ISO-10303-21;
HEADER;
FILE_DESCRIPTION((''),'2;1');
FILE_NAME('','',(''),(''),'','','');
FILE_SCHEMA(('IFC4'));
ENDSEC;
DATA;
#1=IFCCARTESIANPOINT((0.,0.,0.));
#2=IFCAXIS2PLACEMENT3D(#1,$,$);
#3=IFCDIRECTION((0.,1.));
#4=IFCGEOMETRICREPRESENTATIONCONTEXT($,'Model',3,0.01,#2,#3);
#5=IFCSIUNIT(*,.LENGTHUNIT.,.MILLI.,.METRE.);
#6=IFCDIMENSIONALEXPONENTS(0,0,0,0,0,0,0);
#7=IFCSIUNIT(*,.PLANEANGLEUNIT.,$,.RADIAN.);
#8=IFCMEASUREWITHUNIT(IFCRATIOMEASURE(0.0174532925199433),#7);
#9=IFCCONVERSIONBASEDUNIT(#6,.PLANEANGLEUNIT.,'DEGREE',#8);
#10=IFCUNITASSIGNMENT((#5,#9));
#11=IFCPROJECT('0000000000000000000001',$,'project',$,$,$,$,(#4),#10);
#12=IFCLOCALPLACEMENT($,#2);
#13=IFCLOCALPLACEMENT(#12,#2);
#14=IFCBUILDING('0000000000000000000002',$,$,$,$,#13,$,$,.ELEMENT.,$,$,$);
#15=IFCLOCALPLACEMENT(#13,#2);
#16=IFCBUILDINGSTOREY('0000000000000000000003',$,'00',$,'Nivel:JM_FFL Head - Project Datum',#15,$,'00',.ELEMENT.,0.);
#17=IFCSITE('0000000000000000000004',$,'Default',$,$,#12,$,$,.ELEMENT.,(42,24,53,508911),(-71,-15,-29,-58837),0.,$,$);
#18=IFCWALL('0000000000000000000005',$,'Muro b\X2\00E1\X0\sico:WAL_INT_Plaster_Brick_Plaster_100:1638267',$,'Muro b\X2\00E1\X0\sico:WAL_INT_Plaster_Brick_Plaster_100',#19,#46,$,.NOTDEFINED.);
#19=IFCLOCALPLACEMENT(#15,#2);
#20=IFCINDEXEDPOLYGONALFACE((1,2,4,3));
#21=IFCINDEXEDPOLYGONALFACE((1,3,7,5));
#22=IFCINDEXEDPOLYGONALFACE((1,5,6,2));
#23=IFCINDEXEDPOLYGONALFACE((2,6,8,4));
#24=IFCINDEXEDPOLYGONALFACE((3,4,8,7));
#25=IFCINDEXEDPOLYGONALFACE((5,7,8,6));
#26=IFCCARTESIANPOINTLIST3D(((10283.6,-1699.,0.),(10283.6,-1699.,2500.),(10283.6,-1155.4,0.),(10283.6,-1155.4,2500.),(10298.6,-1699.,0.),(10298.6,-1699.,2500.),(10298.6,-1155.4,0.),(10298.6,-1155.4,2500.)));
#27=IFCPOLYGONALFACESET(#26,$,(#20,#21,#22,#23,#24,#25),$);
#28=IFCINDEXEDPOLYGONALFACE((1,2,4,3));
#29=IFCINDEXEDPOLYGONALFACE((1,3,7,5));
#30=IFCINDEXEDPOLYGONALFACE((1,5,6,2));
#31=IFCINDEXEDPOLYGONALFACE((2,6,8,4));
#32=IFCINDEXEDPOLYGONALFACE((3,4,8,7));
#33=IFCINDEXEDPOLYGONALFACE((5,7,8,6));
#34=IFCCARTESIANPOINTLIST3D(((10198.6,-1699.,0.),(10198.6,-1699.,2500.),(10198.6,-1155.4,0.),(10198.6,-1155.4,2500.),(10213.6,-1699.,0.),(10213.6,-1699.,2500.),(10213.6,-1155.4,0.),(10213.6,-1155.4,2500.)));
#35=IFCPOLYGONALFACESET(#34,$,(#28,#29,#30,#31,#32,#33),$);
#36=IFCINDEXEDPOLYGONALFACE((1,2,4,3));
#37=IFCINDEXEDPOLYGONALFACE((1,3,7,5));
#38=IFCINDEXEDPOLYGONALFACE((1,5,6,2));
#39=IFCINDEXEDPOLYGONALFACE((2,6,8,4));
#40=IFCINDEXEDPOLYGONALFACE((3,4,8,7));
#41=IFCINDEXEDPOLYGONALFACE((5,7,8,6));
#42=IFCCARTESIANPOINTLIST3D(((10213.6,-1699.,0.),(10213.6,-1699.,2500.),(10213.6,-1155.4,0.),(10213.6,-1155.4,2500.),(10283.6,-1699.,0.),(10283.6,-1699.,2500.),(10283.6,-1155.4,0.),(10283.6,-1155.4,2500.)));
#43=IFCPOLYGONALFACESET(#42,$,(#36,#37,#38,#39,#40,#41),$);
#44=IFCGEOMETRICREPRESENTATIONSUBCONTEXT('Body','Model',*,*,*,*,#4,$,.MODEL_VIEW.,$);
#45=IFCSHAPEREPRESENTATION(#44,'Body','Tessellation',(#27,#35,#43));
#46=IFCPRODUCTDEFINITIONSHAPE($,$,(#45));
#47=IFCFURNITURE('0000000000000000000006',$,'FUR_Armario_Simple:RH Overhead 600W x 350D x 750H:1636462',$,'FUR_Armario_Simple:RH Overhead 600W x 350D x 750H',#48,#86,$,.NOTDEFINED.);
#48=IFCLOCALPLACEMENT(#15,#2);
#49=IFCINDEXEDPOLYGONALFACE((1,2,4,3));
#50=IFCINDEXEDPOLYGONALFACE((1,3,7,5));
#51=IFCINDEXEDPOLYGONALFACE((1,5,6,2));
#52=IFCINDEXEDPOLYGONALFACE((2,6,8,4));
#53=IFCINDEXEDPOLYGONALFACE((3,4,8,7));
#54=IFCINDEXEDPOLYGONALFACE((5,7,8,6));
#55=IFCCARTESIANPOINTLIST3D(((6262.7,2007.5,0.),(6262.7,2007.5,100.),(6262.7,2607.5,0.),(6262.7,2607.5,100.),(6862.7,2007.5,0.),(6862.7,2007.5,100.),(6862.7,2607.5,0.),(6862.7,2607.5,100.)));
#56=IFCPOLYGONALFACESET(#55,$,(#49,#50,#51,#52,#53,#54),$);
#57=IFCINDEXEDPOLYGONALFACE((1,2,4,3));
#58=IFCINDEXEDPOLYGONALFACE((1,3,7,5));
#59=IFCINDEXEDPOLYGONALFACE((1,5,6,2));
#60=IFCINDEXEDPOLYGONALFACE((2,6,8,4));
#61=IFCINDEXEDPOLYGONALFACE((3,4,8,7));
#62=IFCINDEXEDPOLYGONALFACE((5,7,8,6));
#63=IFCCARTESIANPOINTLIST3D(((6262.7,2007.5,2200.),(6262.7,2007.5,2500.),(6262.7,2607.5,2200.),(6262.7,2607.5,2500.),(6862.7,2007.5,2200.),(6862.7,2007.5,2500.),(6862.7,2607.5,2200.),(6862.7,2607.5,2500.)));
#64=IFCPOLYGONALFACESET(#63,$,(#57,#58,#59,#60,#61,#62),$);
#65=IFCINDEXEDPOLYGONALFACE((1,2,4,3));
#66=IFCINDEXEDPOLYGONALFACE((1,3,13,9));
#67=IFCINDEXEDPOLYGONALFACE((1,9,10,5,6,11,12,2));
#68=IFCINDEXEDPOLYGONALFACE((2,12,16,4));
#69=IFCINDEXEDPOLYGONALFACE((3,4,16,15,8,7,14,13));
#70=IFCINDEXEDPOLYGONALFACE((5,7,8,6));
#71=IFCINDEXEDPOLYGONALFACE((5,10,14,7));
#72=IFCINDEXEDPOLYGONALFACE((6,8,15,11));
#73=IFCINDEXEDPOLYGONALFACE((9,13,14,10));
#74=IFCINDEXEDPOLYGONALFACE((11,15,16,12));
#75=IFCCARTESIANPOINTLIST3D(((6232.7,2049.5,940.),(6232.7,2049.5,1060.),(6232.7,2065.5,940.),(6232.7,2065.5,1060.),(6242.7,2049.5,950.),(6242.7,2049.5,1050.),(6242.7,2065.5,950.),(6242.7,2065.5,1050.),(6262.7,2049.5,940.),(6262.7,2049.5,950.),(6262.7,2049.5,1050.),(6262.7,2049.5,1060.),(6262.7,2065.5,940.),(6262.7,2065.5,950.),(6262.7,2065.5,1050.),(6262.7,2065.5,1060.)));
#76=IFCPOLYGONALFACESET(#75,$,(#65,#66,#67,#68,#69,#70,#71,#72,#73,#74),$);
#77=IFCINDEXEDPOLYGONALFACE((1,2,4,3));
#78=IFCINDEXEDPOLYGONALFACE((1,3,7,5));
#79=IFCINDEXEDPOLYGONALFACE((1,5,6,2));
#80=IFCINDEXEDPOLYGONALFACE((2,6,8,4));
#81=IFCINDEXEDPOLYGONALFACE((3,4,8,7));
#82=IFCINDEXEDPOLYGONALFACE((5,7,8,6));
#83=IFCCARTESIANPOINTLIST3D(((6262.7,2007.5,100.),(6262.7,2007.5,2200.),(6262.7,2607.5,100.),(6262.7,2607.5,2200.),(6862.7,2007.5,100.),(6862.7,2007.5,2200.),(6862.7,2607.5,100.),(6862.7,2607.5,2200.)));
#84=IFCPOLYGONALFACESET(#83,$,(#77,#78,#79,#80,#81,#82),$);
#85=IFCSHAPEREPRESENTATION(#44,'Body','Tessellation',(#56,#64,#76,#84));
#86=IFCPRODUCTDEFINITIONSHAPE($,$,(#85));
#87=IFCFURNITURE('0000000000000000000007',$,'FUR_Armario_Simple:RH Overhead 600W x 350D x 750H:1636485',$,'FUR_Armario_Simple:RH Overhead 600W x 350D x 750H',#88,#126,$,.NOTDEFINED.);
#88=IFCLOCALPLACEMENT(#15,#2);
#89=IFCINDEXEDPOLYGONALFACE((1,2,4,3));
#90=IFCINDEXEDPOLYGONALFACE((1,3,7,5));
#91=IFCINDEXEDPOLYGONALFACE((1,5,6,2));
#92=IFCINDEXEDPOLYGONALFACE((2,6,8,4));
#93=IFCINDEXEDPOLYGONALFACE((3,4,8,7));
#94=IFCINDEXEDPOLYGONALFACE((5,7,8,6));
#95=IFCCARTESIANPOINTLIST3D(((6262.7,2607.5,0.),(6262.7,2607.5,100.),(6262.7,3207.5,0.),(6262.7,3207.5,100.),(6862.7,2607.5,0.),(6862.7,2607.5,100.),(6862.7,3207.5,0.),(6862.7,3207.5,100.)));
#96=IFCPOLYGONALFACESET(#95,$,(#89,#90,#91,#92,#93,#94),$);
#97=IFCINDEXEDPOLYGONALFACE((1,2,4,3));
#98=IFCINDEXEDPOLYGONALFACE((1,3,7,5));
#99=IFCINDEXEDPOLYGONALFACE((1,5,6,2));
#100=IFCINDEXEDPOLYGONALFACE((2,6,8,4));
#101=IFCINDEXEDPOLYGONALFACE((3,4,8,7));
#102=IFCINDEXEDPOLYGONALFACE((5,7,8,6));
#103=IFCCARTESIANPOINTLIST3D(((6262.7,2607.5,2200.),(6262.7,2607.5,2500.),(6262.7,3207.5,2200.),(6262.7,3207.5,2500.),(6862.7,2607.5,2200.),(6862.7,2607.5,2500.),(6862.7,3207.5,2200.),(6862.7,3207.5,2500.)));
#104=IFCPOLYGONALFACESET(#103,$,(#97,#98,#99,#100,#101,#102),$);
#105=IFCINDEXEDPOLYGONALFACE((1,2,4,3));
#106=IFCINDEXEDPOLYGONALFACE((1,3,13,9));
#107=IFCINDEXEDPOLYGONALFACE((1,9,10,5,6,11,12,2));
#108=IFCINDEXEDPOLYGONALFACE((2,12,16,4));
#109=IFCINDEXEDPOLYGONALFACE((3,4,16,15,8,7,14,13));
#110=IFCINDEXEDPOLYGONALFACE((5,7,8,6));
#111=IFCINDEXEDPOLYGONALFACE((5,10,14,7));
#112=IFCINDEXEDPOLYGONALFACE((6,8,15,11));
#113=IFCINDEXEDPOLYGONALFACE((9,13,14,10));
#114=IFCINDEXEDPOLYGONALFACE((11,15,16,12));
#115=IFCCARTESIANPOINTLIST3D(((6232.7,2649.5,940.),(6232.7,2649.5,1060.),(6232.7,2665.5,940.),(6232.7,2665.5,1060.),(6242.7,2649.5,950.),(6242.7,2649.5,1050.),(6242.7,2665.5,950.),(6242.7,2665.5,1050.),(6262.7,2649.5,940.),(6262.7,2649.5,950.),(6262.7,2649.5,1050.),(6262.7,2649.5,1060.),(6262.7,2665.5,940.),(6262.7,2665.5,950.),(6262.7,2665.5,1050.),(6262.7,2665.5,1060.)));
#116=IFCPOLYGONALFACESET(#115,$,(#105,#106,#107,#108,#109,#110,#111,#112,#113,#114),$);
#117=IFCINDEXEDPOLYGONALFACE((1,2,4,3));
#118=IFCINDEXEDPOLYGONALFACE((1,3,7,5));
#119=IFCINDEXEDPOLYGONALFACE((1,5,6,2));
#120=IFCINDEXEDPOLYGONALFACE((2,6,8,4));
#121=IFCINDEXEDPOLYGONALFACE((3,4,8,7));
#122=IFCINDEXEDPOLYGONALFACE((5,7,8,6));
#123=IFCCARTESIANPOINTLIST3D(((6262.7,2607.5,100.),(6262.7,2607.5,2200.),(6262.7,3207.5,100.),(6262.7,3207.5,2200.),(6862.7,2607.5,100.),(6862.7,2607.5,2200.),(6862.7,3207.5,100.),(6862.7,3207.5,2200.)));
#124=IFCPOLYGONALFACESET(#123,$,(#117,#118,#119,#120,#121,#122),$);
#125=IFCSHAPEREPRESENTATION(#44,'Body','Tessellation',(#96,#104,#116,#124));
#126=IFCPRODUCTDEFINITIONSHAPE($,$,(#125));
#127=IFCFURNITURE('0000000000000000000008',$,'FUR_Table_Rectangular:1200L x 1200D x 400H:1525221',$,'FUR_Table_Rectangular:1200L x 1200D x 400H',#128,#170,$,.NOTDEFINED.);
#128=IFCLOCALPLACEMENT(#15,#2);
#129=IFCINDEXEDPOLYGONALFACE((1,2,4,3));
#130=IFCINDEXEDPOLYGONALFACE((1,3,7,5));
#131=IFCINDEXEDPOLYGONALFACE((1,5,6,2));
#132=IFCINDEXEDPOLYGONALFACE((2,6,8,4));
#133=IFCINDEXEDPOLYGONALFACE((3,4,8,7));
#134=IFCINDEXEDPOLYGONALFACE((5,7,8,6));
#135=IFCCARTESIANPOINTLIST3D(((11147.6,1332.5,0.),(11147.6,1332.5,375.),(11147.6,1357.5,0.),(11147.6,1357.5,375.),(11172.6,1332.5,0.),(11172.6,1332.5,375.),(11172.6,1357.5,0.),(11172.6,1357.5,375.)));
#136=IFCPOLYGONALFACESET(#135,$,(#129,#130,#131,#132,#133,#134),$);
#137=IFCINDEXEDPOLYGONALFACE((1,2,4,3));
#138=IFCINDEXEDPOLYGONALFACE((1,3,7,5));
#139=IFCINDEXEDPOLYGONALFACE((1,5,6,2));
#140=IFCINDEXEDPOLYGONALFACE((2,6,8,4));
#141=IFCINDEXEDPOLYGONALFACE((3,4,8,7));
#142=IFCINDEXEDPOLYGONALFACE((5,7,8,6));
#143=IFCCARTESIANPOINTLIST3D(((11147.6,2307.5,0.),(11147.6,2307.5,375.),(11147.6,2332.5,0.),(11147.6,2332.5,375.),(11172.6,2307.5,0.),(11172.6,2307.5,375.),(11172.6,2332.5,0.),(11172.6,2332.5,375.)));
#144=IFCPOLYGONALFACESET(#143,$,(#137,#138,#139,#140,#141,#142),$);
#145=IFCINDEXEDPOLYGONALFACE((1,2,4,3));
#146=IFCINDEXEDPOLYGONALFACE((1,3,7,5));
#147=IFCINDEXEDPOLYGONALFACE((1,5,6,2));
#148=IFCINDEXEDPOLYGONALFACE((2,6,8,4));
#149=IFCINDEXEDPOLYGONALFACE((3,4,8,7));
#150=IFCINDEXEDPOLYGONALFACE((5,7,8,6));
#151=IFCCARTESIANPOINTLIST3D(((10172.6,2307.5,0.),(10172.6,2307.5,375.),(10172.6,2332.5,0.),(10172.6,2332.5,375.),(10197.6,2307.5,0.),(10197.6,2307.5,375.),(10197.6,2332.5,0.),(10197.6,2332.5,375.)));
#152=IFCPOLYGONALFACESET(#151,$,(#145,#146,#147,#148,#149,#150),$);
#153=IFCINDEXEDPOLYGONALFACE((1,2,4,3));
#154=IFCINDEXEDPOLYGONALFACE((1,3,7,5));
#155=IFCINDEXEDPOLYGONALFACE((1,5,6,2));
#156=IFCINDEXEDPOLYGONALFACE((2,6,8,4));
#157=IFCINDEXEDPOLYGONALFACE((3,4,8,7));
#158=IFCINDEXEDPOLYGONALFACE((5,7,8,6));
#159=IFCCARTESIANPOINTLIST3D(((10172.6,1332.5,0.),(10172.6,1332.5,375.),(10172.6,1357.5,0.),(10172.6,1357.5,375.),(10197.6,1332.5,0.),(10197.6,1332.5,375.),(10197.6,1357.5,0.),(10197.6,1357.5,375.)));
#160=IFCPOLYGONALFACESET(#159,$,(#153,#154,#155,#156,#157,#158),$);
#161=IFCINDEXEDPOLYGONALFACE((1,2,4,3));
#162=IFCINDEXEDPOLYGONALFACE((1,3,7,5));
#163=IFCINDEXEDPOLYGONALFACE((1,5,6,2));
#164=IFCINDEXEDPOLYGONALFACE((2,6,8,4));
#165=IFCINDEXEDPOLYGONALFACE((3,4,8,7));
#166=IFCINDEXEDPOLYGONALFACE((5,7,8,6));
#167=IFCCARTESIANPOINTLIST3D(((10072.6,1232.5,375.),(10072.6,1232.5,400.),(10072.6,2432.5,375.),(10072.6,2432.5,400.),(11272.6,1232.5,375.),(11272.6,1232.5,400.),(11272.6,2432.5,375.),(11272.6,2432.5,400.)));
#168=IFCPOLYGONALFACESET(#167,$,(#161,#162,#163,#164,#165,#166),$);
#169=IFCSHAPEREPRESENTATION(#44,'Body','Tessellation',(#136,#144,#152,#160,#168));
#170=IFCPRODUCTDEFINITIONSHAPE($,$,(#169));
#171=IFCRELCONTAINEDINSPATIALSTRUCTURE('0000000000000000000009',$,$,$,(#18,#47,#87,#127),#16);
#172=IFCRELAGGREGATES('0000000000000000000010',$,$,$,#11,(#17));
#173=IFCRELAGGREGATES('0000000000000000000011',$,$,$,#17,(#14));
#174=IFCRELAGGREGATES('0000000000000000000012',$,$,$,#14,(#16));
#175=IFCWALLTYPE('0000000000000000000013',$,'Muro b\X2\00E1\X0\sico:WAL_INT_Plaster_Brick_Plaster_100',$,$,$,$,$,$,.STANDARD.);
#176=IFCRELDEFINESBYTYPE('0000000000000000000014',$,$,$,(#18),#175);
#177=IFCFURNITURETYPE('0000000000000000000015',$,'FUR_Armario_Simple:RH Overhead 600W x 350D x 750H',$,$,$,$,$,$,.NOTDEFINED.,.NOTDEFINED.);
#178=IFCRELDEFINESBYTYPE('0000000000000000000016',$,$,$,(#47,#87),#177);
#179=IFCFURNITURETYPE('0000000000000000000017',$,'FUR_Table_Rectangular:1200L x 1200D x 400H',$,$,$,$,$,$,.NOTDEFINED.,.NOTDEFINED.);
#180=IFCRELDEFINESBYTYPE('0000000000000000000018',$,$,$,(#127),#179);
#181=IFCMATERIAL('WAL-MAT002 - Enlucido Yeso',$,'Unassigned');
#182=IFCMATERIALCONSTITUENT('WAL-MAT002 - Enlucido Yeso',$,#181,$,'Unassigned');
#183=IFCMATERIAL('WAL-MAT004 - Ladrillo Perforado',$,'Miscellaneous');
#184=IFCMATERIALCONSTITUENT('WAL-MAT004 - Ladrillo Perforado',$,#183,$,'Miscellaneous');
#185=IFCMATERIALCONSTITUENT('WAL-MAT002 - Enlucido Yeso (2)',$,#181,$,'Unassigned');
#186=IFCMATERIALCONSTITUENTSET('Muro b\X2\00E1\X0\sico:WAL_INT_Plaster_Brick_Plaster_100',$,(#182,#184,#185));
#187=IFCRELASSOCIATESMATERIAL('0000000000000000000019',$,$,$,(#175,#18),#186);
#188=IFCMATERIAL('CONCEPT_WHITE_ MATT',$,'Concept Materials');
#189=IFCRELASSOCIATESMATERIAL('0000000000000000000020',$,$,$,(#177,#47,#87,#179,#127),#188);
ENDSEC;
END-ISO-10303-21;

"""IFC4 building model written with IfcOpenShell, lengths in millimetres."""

from ifc_helpers import new_model, entity, si_unit, converted_unit, direction, frame, origin, place, context, subcontext, project, spatial, indexed_curve, outline, extrude, source, transform, mapped, material, constituent, constituent_set, type_object, type_shapes, element, save


model = new_model("IFC4")

# Units and contexts
model_context = context("Model", 3, precision=0.01, world=origin(), true_north=direction((0.0, 1.0)))
body_context = subcontext(model_context, "Body", "Model", "MODEL_VIEW")
ifc_project = project(units=[si_unit("LENGTHUNIT", "METRE", prefix="MILLI"), converted_unit("PLANEANGLEUNIT", "DEGREE", entity("IfcRatioMeasure", 0.0174532925199433), si_unit("PLANEANGLEUNIT", "RADIAN"), dimensions=[0, 0, 0, 0, 0, 0, 0])], contexts=[model_context])

# Site, building, storey
site_placement = place(None, origin())
site = spatial("IfcSite", under=ifc_project, at=site_placement, Name="Default", CompositionType="ELEMENT", RefLatitude=(42, 24, 53, 508911), RefLongitude=(-71, -15, -29, -58837), RefElevation=0.0)
building_placement = place(site_placement, origin())
building = spatial("IfcBuilding", under=site, at=building_placement, CompositionType="ELEMENT")
storey_placement = place(building_placement, origin())
storey = spatial("IfcBuildingStorey", under=building, at=storey_placement, Name="00", ObjectType="Nivel:JM_FFL Head - Project Datum", LongName="00", CompositionType="ELEMENT", Elevation=0.0)

# Wall
ifc_material_1 = material(Name="WAL-MAT002 - Enlucido Yeso", Category="Unassigned")
ifc_constituent_1 = constituent(ifc_material_1, Name="WAL-MAT002 - Enlucido Yeso", Category="Unassigned")
ifc_material_2 = material(Name="WAL-MAT004 - Ladrillo Perforado", Category="Miscellaneous")
ifc_constituent_2 = constituent(ifc_material_2, Name="WAL-MAT004 - Ladrillo Perforado", Category="Miscellaneous")
ifc_constituent_3 = constituent(ifc_material_1, Name="WAL-MAT002 - Enlucido Yeso (2)", Category="Unassigned")
ifc_constituent_set_1 = constituent_set(constituents=[ifc_constituent_1, ifc_constituent_2, ifc_constituent_3], Name="Muro básico:WAL_INT_Plaster_Brick_Plaster_100")
wall_type = type_object("IfcWallType", Name="Muro básico:WAL_INT_Plaster_Brick_Plaster_100", PredefinedType="STANDARD", material=ifc_constituent_set_1)
wall_1_placement = place(storey_placement, frame((10248.6, -1155.4, 0.0), z_axis=(0.0, 0.0, 1.0), x_axis=(0.0, -1.0, 0.0)))
element("IfcWall", 1, at=wall_1_placement, inside=storey, type_object=wall_type, material=ifc_constituent_set_1, Name="Muro básico:WAL_INT_Plaster_Brick_Plaster_100:1638267", ObjectType="Muro básico:WAL_INT_Plaster_Brick_Plaster_100", PredefinedType="NOTDEFINED", context=body_context, shape_type="SweptSolid", body=[
    extrude(outline(indexed_curve([(-7.5, -271.8), (7.5, -271.8), (7.5, 271.8), (-7.5, 271.8), (-7.5, -271.8)], self_intersect=False)), frame((271.8, 42.5, 0.0), z_axis=(0.0, 0.0, 1.0), x_axis=(0.0, -1.0, 0.0)), (0.0, 0.0, 1.0), 2500.0),
    extrude(outline(indexed_curve([(-7.5, -271.8), (7.5, -271.8), (7.5, 271.8), (-7.5, 271.8), (-7.5, -271.8)], self_intersect=False)), frame((271.8, -42.5, 0.0), z_axis=(0.0, 0.0, 1.0), x_axis=(0.0, 1.0, 0.0)), (0.0, 0.0, 1.0), 2500.0),
    extrude(outline(indexed_curve([(-271.8, -35.0), (271.8, -35.0), (271.8, 35.0), (-271.8, 35.0), (-271.8, -35.0)], self_intersect=False)), frame((271.8, 0.0, 0.0)), (0.0, 0.0, 1.0), 2500.0),
])

# Furniture
ifc_material_3 = material(Name="CONCEPT_WHITE_ MATT", Category="Concept Materials")
furniture_type_1 = type_object("IfcFurnitureType", Name="FUR_Armario_Simple:RH Overhead 600W x 350D x 750H", AssemblyPlace="NOTDEFINED", PredefinedType="NOTDEFINED", material=ifc_material_3)
shared_shape_1 = source(origin(), body_context, "Body", "SweptSolid", [
    extrude(outline(indexed_curve([(-300.0, -300.0), (300.0, -300.0), (300.0, 300.0), (-300.0, 300.0), (-300.0, -300.0)], self_intersect=False)), frame((300.0, -300.0, 0.0), z_axis=(0.0, 0.0, 1.0), x_axis=(-1.0, 0.0, 0.0)), (0.0, 0.0, 1.0), 100.0),
    extrude(outline(indexed_curve([(-300.0, -300.0), (300.0, -300.0), (300.0, 300.0), (-300.0, 300.0), (-300.0, -300.0)], self_intersect=False)), frame((300.0, -300.0, 2200.0), z_axis=(0.0, 0.0, 1.0), x_axis=(-1.0, 0.0, 0.0)), (0.0, 0.0, 1.0), 300.0),
    extrude(outline(indexed_curve([(-60.0, -17.5), (60.0, -17.5), (60.0, 12.5), (50.0, 12.5), (50.0, -7.5), (-50.0, -7.5), (-50.0, 12.5), (-60.0, 12.5), (-60.0, -17.5)], self_intersect=False)), frame((542.0, -612.5, 1000.0), z_axis=(1.0, 0.0, 0.0), x_axis=(0.0, 0.0, -1.0)), (0.0, 0.0, 1.0), 16.0),
    extrude(outline(indexed_curve([(-300.0, -300.0), (300.0, -300.0), (300.0, 300.0), (-300.0, 300.0), (-300.0, -300.0)], self_intersect=False)), frame((300.0, -300.0, 100.0), z_axis=(0.0, 0.0, 1.0), x_axis=(0.0, 1.0, 0.0)), (0.0, 0.0, 1.0), 2100.0),
])
type_shapes(furniture_type_1, [shared_shape_1])
for number, where, z_axis, x_axis, name in (
    (2, (6862.7, 2607.5, 0.0), (0.0, 0.0, 1.0), (0.0, -1.0, 0.0), "FUR_Armario_Simple:RH Overhead 600W x 350D x 750H:1636462"),
    (3, (6862.7, 3207.5, 0.0), (0.0, 0.0, 1.0), (0.0, -1.0, 0.0), "FUR_Armario_Simple:RH Overhead 600W x 350D x 750H:1636485"),
):
    element("IfcFurniture", number, at=place(storey_placement, frame(where, z_axis=z_axis, x_axis=x_axis)), inside=storey, type_object=furniture_type_1, material=ifc_material_3, Name=name, ObjectType="FUR_Armario_Simple:RH Overhead 600W x 350D x 750H", PredefinedType="NOTDEFINED", context=body_context, shape_type="MappedRepresentation", body=[
        mapped(shared_shape_1, transform((0.0, 0.0, 0.0), scale=1.0)),
    ])
furniture_type_2 = type_object("IfcFurnitureType", Name="FUR_Table_Rectangular:1200L x 1200D x 400H", AssemblyPlace="NOTDEFINED", PredefinedType="NOTDEFINED", material=ifc_material_3)
shared_shape_2 = source(origin(), body_context, "Body", "SweptSolid", [
    extrude(outline(indexed_curve([(-12.5, -12.5), (12.5, -12.5), (12.5, 12.5), (-12.5, 12.5), (-12.5, -12.5)], self_intersect=False)), frame((87.5, 687.5, 0.0), z_axis=(0.0, 0.0, 1.0), x_axis=(-1.0, 0.0, 0.0)), (0.0, 0.0, 1.0), 375.0),
    extrude(outline(indexed_curve([(-12.5, -12.5), (12.5, -12.5), (12.5, 12.5), (-12.5, 12.5), (-12.5, -12.5)], self_intersect=False)), frame((-887.5, 687.5, 0.0), z_axis=(0.0, 0.0, 1.0), x_axis=(-1.0, 0.0, 0.0)), (0.0, 0.0, 1.0), 375.0),
    extrude(outline(indexed_curve([(-12.5, -12.5), (12.5, -12.5), (12.5, 12.5), (-12.5, 12.5), (-12.5, -12.5)], self_intersect=False)), frame((-887.5, -287.5, 0.0), z_axis=(0.0, 0.0, 1.0), x_axis=(-1.0, 0.0, 0.0)), (0.0, 0.0, 1.0), 375.0),
    extrude(outline(indexed_curve([(-12.5, -12.5), (12.5, -12.5), (12.5, 12.5), (-12.5, 12.5), (-12.5, -12.5)], self_intersect=False)), frame((87.5, -287.5, 0.0), z_axis=(0.0, 0.0, 1.0), x_axis=(-1.0, 0.0, 0.0)), (0.0, 0.0, 1.0), 375.0),
    extrude(outline(indexed_curve([(-600.0, -600.0), (600.0, -600.0), (600.0, 600.0), (-600.0, 600.0), (-600.0, -600.0)], self_intersect=False)), frame((-400.0, 200.0, 375.0), z_axis=(0.0, 0.0, 1.0), x_axis=(-1.0, 0.0, 0.0)), (0.0, 0.0, 1.0), 25.0),
])
type_shapes(furniture_type_2, [shared_shape_2])
furniture_1_placement = place(storey_placement, frame((10472.6, 1432.5, 0.0), z_axis=(0.0, 0.0, 1.0), x_axis=(0.0, -1.0, 0.0)))
element("IfcFurniture", 4, at=furniture_1_placement, inside=storey, type_object=furniture_type_2, material=ifc_material_3, Name="FUR_Table_Rectangular:1200L x 1200D x 400H:1525221", ObjectType="FUR_Table_Rectangular:1200L x 1200D x 400H", PredefinedType="NOTDEFINED", context=body_context, shape_type="MappedRepresentation", body=[
    mapped(shared_shape_2, transform((0.0, 0.0, 0.0), scale=1.0)),
])

save(model, "model.ifc")
